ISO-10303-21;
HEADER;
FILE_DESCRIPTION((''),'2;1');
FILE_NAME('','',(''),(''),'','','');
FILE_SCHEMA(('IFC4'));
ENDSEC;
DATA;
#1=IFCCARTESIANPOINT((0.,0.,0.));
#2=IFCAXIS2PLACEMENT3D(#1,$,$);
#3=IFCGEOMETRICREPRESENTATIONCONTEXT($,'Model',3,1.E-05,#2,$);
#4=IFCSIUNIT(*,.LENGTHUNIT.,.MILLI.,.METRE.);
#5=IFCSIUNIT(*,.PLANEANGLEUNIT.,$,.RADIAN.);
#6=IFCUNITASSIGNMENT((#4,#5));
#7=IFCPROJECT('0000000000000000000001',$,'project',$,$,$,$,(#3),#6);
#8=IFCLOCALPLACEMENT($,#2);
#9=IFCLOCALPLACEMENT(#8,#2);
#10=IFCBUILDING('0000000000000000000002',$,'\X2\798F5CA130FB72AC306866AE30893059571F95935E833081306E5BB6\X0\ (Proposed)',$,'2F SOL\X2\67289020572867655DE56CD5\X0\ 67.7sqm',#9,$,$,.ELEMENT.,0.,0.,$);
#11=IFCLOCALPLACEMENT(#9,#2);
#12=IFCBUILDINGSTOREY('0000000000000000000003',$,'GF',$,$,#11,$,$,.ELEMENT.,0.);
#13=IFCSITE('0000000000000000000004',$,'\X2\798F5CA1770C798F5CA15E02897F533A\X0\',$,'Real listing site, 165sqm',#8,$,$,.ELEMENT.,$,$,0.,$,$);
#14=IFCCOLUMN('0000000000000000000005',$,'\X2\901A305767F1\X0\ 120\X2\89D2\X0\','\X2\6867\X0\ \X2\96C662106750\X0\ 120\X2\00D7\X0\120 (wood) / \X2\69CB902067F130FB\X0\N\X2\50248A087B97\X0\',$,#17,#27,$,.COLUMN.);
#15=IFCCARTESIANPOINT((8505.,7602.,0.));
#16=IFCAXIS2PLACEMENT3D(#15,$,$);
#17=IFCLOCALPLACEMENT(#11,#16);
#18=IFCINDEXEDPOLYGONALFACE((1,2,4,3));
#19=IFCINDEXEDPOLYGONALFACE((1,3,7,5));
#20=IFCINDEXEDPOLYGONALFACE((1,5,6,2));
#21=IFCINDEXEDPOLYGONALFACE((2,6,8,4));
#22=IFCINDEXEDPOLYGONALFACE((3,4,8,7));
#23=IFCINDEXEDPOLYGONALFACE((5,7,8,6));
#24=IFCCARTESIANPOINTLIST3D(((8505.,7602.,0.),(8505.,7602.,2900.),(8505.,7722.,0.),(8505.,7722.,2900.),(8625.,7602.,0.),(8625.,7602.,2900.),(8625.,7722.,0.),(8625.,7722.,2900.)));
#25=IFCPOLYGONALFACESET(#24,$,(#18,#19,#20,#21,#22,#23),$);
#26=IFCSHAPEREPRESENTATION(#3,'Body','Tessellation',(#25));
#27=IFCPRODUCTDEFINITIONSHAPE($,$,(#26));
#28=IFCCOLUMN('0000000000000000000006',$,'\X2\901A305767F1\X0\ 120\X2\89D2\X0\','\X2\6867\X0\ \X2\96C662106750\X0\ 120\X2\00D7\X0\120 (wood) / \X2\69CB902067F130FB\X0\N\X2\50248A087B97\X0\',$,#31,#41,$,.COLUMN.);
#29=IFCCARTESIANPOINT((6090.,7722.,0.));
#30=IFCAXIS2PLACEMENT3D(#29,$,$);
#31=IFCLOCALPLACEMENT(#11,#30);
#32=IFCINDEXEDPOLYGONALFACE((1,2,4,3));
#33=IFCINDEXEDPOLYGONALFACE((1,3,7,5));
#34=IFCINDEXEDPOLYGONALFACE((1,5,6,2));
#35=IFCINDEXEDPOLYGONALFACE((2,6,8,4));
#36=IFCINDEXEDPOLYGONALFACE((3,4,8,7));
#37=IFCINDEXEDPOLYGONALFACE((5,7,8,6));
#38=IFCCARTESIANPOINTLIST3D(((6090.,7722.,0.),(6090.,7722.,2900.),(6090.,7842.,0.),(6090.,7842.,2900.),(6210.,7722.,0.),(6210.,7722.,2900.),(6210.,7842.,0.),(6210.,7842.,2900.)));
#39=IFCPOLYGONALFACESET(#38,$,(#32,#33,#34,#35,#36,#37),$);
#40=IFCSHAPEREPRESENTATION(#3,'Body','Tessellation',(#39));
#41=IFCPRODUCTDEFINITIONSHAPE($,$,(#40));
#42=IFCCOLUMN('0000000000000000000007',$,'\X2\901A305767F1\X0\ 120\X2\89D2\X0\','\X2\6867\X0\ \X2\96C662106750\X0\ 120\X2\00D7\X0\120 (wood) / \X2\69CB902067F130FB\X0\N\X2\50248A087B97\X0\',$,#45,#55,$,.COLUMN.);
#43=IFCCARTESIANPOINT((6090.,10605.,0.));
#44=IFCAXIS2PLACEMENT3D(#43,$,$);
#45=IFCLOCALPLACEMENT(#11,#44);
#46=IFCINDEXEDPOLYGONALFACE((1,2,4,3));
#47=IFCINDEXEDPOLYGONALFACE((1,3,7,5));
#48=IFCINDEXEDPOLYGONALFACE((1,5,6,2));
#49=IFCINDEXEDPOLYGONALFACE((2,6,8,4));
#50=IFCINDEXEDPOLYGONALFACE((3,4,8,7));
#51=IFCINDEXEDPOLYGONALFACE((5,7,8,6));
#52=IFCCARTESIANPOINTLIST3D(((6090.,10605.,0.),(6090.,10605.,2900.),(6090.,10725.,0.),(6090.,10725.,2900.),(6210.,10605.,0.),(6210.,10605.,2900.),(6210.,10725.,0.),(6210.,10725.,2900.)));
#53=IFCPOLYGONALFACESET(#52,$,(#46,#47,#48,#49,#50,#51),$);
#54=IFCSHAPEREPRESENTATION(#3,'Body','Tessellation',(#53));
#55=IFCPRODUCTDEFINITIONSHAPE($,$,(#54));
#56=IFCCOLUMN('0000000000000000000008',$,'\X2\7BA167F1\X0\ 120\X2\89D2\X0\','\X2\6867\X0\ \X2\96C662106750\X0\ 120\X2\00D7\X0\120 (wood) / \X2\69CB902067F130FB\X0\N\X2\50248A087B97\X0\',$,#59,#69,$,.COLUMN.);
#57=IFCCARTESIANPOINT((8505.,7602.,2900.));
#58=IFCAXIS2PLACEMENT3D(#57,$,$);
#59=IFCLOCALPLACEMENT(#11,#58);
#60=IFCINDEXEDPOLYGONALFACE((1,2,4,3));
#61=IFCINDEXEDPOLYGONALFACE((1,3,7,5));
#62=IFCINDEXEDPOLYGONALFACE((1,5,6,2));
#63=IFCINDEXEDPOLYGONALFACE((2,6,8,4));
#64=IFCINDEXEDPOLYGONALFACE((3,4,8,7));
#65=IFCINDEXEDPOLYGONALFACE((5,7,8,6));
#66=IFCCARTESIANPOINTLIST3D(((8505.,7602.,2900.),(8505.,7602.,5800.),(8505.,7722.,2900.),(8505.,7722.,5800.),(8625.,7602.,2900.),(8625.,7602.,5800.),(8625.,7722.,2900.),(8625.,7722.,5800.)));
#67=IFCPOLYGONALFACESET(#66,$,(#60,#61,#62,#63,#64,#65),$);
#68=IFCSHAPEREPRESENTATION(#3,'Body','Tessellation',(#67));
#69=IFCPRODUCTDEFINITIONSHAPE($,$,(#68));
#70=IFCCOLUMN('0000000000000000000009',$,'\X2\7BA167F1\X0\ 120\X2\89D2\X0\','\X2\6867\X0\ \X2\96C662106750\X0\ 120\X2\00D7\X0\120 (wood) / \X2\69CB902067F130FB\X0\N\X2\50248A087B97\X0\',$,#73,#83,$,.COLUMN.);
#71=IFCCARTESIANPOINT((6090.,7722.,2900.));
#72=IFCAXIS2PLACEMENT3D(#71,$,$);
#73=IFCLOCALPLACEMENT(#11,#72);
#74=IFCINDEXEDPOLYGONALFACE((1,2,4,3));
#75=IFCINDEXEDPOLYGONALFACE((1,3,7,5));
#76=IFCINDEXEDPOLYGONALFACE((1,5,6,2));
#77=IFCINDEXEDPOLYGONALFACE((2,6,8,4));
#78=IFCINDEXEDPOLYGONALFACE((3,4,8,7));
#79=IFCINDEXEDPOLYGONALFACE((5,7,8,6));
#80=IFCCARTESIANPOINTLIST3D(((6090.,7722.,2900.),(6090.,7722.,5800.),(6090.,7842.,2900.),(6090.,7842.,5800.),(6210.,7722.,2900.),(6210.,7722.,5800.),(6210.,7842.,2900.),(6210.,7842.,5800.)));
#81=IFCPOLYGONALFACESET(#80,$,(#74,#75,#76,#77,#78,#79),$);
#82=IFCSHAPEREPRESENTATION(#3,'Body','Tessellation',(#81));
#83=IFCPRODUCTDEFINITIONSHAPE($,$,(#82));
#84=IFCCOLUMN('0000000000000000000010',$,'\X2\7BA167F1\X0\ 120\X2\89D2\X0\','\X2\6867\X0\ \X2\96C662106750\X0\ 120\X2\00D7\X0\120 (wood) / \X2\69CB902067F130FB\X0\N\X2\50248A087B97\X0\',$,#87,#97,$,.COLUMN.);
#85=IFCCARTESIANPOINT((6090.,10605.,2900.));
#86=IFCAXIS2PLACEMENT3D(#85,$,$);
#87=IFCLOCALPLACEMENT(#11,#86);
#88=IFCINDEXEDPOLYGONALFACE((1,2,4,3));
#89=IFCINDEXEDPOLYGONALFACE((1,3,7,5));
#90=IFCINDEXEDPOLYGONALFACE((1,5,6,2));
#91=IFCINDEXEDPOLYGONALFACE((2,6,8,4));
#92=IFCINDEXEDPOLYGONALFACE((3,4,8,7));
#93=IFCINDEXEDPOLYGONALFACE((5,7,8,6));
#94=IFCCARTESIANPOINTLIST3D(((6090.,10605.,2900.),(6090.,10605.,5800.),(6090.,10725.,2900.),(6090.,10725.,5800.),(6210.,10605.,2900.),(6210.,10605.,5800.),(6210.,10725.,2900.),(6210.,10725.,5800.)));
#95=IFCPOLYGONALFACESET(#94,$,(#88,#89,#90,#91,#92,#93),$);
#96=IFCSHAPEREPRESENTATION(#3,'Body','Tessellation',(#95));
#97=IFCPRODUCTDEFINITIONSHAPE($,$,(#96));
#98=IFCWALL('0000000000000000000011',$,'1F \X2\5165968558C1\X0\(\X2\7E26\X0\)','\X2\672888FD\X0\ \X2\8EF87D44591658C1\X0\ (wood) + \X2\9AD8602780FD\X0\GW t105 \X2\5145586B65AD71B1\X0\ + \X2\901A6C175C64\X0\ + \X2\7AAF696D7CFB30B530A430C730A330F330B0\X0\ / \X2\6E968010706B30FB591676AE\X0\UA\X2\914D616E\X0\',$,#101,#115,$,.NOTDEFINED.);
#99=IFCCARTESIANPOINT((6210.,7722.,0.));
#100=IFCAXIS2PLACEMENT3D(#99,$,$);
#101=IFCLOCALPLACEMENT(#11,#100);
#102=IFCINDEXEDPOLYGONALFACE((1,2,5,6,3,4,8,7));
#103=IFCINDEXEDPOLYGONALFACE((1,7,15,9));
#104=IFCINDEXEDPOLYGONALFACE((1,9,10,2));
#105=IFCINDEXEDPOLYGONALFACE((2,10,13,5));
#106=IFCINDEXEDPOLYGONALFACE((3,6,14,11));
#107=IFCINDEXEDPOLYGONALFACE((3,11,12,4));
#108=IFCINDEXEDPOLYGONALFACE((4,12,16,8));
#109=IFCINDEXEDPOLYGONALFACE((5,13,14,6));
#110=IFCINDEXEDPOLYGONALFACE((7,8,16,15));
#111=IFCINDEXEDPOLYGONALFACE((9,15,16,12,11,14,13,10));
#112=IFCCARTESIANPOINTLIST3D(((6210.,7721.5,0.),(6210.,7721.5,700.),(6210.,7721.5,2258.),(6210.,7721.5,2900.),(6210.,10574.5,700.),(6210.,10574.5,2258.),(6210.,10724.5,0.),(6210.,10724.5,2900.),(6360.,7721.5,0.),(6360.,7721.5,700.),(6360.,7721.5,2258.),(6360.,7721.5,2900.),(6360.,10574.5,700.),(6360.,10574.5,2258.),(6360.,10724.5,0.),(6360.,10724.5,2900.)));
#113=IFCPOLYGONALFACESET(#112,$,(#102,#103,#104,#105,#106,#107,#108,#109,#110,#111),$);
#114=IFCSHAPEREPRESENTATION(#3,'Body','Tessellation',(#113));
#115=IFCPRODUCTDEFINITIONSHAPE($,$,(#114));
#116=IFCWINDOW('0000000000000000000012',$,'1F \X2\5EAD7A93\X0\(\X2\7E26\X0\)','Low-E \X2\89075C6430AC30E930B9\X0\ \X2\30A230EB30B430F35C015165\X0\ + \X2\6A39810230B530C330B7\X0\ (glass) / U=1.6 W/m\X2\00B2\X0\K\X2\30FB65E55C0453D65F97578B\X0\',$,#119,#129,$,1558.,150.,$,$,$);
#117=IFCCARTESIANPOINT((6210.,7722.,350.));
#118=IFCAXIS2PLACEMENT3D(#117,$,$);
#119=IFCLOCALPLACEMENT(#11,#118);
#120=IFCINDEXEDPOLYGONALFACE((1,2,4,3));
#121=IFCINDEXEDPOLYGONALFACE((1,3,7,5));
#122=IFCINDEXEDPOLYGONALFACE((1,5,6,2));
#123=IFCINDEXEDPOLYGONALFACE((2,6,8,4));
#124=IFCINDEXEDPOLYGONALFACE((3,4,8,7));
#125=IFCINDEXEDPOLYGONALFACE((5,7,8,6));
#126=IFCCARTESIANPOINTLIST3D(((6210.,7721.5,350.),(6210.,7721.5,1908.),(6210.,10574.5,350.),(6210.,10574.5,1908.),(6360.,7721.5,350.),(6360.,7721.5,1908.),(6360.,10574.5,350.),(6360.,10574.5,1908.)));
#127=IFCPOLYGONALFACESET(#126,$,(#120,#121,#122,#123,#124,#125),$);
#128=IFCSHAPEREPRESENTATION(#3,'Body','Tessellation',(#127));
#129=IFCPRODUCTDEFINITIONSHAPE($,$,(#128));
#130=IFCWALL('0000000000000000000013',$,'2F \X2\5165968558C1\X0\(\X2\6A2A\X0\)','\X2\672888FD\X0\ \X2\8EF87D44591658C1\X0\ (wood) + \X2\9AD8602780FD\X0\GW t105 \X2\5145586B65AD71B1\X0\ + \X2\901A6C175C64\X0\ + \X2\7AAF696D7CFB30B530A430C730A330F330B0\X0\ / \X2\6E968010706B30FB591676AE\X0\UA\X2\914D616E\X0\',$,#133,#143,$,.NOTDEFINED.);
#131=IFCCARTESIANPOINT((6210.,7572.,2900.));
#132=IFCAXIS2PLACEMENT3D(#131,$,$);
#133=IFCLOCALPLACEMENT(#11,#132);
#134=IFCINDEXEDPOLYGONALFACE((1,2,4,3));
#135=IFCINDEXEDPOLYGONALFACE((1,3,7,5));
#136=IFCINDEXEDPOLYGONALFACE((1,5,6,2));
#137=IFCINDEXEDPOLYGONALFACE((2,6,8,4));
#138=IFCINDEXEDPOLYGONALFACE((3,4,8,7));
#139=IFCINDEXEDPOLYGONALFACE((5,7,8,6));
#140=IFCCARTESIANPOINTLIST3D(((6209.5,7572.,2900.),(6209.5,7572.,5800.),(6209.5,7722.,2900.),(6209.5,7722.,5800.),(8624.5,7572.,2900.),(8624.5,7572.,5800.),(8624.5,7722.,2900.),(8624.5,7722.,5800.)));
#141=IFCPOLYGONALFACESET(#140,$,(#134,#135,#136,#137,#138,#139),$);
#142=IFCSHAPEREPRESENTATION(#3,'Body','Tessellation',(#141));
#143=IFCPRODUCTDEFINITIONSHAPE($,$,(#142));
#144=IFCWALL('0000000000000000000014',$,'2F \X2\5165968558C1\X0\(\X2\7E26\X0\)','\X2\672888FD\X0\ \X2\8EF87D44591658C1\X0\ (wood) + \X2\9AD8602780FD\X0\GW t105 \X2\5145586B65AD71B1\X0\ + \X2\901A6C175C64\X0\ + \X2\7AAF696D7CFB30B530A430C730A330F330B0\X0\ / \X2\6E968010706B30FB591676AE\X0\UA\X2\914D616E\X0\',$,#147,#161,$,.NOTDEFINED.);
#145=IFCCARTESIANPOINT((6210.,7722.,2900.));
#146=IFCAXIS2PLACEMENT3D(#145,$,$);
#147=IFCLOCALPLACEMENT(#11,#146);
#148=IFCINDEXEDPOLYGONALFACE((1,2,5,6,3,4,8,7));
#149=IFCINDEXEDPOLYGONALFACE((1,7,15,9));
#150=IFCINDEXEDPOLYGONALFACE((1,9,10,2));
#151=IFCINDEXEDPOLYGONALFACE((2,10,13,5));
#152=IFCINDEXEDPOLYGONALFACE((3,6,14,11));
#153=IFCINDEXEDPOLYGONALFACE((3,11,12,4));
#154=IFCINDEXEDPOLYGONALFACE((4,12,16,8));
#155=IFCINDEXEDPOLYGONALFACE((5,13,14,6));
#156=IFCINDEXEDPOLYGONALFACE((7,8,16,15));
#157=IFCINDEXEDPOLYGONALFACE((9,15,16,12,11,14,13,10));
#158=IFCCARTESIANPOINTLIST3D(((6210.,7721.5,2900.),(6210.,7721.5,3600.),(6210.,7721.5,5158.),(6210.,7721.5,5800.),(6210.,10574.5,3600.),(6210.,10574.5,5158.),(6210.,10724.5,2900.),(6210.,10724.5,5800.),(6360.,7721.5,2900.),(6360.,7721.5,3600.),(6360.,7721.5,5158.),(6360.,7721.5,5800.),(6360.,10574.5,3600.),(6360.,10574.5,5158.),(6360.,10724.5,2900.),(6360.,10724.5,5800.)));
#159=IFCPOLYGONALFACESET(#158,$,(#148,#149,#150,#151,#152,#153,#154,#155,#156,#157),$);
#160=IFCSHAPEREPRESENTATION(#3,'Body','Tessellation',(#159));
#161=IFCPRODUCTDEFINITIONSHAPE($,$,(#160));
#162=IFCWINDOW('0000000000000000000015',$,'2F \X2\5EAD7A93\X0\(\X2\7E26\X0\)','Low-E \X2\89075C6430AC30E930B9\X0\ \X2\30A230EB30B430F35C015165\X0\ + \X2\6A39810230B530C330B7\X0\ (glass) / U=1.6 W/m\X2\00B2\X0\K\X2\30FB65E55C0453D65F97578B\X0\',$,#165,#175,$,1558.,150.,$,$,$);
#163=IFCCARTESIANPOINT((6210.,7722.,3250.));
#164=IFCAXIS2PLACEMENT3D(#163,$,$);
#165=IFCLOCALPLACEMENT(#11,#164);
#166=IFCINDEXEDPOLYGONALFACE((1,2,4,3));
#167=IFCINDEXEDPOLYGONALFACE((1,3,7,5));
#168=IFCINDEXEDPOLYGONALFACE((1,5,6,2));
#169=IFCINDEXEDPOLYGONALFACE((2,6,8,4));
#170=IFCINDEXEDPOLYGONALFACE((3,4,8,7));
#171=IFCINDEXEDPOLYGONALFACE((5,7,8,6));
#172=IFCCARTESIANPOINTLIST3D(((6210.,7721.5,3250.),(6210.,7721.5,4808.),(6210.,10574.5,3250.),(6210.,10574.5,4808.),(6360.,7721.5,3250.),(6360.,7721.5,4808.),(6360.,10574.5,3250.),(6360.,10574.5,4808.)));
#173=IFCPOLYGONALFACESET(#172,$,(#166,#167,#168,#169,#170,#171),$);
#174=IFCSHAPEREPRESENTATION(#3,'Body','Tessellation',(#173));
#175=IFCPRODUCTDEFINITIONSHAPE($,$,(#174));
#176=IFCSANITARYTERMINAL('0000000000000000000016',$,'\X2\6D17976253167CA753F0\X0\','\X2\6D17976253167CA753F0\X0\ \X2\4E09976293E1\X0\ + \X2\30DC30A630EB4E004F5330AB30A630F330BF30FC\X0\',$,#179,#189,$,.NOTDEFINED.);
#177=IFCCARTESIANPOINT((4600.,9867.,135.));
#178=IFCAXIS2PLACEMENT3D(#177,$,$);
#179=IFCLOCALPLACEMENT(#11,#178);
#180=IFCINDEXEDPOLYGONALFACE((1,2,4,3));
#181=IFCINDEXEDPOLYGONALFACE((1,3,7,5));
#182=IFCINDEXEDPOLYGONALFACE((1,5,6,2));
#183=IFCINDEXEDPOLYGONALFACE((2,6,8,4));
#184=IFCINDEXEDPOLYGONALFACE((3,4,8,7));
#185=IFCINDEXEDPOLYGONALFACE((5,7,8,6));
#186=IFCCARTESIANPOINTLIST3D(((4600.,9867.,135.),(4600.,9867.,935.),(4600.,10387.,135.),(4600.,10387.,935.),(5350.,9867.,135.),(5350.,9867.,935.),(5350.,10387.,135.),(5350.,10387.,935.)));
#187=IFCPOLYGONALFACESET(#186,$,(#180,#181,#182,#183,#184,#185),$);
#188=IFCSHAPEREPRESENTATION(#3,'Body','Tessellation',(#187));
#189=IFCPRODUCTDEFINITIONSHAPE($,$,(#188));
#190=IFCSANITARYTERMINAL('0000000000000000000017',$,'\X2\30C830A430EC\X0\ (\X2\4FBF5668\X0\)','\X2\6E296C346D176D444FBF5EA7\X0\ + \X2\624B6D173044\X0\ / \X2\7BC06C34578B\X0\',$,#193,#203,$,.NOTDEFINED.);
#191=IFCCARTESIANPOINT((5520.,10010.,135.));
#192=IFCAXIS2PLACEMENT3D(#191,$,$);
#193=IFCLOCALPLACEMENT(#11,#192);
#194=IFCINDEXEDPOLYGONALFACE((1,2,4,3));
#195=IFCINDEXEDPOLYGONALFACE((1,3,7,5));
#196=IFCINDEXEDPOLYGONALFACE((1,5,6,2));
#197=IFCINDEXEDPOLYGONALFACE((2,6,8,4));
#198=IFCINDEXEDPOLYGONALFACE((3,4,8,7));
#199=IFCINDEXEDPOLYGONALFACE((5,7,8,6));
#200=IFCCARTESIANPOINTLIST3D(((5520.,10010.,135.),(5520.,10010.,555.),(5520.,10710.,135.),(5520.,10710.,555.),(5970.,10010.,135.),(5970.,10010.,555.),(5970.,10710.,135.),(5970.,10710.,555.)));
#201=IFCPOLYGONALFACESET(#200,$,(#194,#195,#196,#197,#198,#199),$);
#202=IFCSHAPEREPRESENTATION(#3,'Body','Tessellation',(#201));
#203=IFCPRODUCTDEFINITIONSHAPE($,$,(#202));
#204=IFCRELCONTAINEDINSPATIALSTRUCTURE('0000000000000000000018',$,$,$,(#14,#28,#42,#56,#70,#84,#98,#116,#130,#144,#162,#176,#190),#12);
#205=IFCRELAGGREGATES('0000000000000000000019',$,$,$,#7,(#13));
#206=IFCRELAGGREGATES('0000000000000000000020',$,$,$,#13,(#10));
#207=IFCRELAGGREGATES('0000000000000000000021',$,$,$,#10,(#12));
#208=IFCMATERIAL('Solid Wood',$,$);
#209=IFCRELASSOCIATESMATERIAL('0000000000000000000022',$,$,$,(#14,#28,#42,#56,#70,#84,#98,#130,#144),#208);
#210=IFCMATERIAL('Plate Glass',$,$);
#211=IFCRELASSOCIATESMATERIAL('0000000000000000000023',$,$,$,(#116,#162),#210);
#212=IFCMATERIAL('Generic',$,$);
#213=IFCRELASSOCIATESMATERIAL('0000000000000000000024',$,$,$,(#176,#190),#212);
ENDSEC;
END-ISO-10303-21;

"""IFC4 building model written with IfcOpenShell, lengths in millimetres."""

from ifc_helpers import new_model, si_unit, frame, frame_2d, origin, place, context, project, spatial, rectangle, extrude, material, element, fill, save


model = new_model("IFC4")

# Units and contexts
model_context = context("Model", 3, precision=1e-05, world=origin())
ifc_project = project(units=[si_unit("LENGTHUNIT", "METRE", prefix="MILLI"), si_unit("PLANEANGLEUNIT", "RADIAN")], contexts=[model_context])

# Site, building, storey
site_placement = place(None, origin())
site = spatial("IfcSite", under=ifc_project, at=site_placement, Name="福岡県福岡市西区", ObjectType="Real listing site, 165sqm", CompositionType="ELEMENT", RefElevation=0.0)
building_placement = place(site_placement, origin())
building = spatial("IfcBuilding", under=site, at=building_placement, Name="福岡・犬と暮らす土間広めの家 (Proposed)", ObjectType="2F SOL木造在来工法 67.7sqm", CompositionType="ELEMENT", ElevationOfRefHeight=0.0, ElevationOfTerrain=0.0)
storey_placement = place(building_placement, origin())
storey = spatial("IfcBuildingStorey", under=building, at=storey_placement, Name="GF", CompositionType="ELEMENT", Elevation=0.0)

# Columns
ifc_material_1 = material(Name="Solid Wood")
column_1_placement = place(storey_placement, frame((8505.0, 7602.0, 0.0)))
element("IfcColumn", 1, at=column_1_placement, inside=storey, material=ifc_material_1, Name="通し柱 120角", Description="桧 集成材 120×120 (wood) / 構造柱・N値計算", PredefinedType="COLUMN", context=model_context, shape_type="SweptSolid", body=[
    extrude(rectangle(XDim=120.0, YDim=120.0, at=frame_2d((60.0, 60.0))), frame((8505.0, 7602.0, 0.0)), (0.0, 0.0, 1.0), 2900.0),
])
column_2_placement = place(storey_placement, frame((6090.0, 7722.0, 0.0)))
element("IfcColumn", 2, at=column_2_placement, inside=storey, material=ifc_material_1, Name="通し柱 120角", Description="桧 集成材 120×120 (wood) / 構造柱・N値計算", PredefinedType="COLUMN", context=model_context, shape_type="SweptSolid", body=[
    extrude(rectangle(XDim=120.0, YDim=120.0, at=frame_2d((60.0, 60.0))), frame((6090.0, 7722.0, 0.0)), (0.0, 0.0, 1.0), 2900.0),
])
column_3_placement = place(storey_placement, frame((6090.0, 10605.0, 0.0)))
element("IfcColumn", 3, at=column_3_placement, inside=storey, material=ifc_material_1, Name="通し柱 120角", Description="桧 集成材 120×120 (wood) / 構造柱・N値計算", PredefinedType="COLUMN", context=model_context, shape_type="SweptSolid", body=[
    extrude(rectangle(XDim=120.0, YDim=120.0, at=frame_2d((60.0, 60.0))), frame((6090.0, 10605.0, 0.0)), (0.0, 0.0, 1.0), 2900.0),
])
column_4_placement = place(storey_placement, frame((8505.0, 7602.0, 2900.0)))
element("IfcColumn", 4, at=column_4_placement, inside=storey, material=ifc_material_1, Name="管柱 120角", Description="桧 集成材 120×120 (wood) / 構造柱・N値計算", PredefinedType="COLUMN", context=model_context, shape_type="SweptSolid", body=[
    extrude(rectangle(XDim=120.0, YDim=120.0, at=frame_2d((60.0, 60.0))), frame((8505.0, 7602.0, 2900.0)), (0.0, 0.0, 1.0), 2900.0),
])
column_5_placement = place(storey_placement, frame((6090.0, 7722.0, 2900.0)))
element("IfcColumn", 5, at=column_5_placement, inside=storey, material=ifc_material_1, Name="管柱 120角", Description="桧 集成材 120×120 (wood) / 構造柱・N値計算", PredefinedType="COLUMN", context=model_context, shape_type="SweptSolid", body=[
    extrude(rectangle(XDim=120.0, YDim=120.0, at=frame_2d((60.0, 60.0))), frame((6090.0, 7722.0, 2900.0)), (0.0, 0.0, 1.0), 2900.0),
])
column_6_placement = place(storey_placement, frame((6090.0, 10605.0, 2900.0)))
element("IfcColumn", 6, at=column_6_placement, inside=storey, material=ifc_material_1, Name="管柱 120角", Description="桧 集成材 120×120 (wood) / 構造柱・N値計算", PredefinedType="COLUMN", context=model_context, shape_type="SweptSolid", body=[
    extrude(rectangle(XDim=120.0, YDim=120.0, at=frame_2d((60.0, 60.0))), frame((6090.0, 10605.0, 2900.0)), (0.0, 0.0, 1.0), 2900.0),
])

# Wall, opening, window
wall_1_placement = place(storey_placement, frame((6210.0, 7722.0, 0.0)))
wall_1 = element("IfcWall", 7, at=wall_1_placement, inside=storey, material=ifc_material_1, Name="1F 入隅壁(縦)", Description="木製 軸組外壁 (wood) + 高性能GW t105 充填断熱 + 通気層 + 窯業系サイディング / 準耐火・外皮UA配慮", PredefinedType="NOTDEFINED", context=model_context, shape_type="SweptSolid", body=[
    extrude(rectangle(XDim=150.0, YDim=3003.0, at=frame_2d((75.0, 1501.0))), frame((6210.0, 7722.0, 0.0)), (0.0, 0.0, 1.0), 2900.0),
])
opening_1_placement = place(storey_placement, frame((6210.0, 7722.0, 350.0)))
opening_1 = element("IfcOpeningElement", 8, at=opening_1_placement, cuts=wall_1, PredefinedType="NOTDEFINED", context=model_context, shape_type="SweptSolid", body=[
    extrude(rectangle(XDim=150.0, YDim=2853.0, at=frame_2d((75.0, 1426.0))), frame((6210.0, 7722.0, 350.0)), (0.0, 0.0, 1.0), 1558.0),
])
ifc_material_2 = material(Name="Plate Glass")
window_1_placement = place(storey_placement, frame((6210.0, 7722.0, 350.0)))
window_1 = element("IfcWindow", 9, at=window_1_placement, inside=storey, material=ifc_material_2, Name="1F 庭窓(縦)", Description="Low-E 複層ガラス アルゴン封入 + 樹脂サッシ (glass) / U=1.6 W/m²K・日射取得型", OverallHeight=1558.0, OverallWidth=150.0, context=model_context, shape_type="SweptSolid", body=[
    extrude(rectangle(XDim=150.0, YDim=2853.0, at=frame_2d((75.0, 1426.0))), frame((6210.0, 7722.0, 350.0)), (0.0, 0.0, 1.0), 1558.0),
])
fill(opening_1, window_1)

# Wall
wall_2_placement = place(storey_placement, frame((6210.0, 7572.0, 2900.0)))
element("IfcWall", 10, at=wall_2_placement, inside=storey, material=ifc_material_1, Name="2F 入隅壁(横)", Description="木製 軸組外壁 (wood) + 高性能GW t105 充填断熱 + 通気層 + 窯業系サイディング / 準耐火・外皮UA配慮", PredefinedType="NOTDEFINED", context=model_context, shape_type="SweptSolid", body=[
    extrude(rectangle(XDim=2415.0, YDim=150.0, at=frame_2d((1207.0, 75.0))), frame((6210.0, 7572.0, 2900.0)), (0.0, 0.0, 1.0), 2900.0),
])

# Wall, opening, window
wall_3_placement = place(storey_placement, frame((6210.0, 7722.0, 2900.0)))
wall_3 = element("IfcWall", 11, at=wall_3_placement, inside=storey, material=ifc_material_1, Name="2F 入隅壁(縦)", Description="木製 軸組外壁 (wood) + 高性能GW t105 充填断熱 + 通気層 + 窯業系サイディング / 準耐火・外皮UA配慮", PredefinedType="NOTDEFINED", context=model_context, shape_type="SweptSolid", body=[
    extrude(rectangle(XDim=150.0, YDim=3003.0, at=frame_2d((75.0, 1501.0))), frame((6210.0, 7722.0, 2900.0)), (0.0, 0.0, 1.0), 2900.0),
])
opening_2_placement = place(storey_placement, frame((6210.0, 7722.0, 3250.0)))
opening_2 = element("IfcOpeningElement", 12, at=opening_2_placement, cuts=wall_3, PredefinedType="NOTDEFINED", context=model_context, shape_type="SweptSolid", body=[
    extrude(rectangle(XDim=150.0, YDim=2853.0, at=frame_2d((75.0, 1426.0))), frame((6210.0, 7722.0, 3250.0)), (0.0, 0.0, 1.0), 1558.0),
])
window_2_placement = place(storey_placement, frame((6210.0, 7722.0, 3250.0)))
window_2 = element("IfcWindow", 13, at=window_2_placement, inside=storey, material=ifc_material_2, Name="2F 庭窓(縦)", Description="Low-E 複層ガラス アルゴン封入 + 樹脂サッシ (glass) / U=1.6 W/m²K・日射取得型", OverallHeight=1558.0, OverallWidth=150.0, context=model_context, shape_type="SweptSolid", body=[
    extrude(rectangle(XDim=150.0, YDim=2853.0, at=frame_2d((75.0, 1426.0))), frame((6210.0, 7722.0, 3250.0)), (0.0, 0.0, 1.0), 1558.0),
])
fill(opening_2, window_2)

# Sanitary terminals
ifc_material_3 = material(Name="Generic")
sanitary_terminal_1_placement = place(storey_placement, frame((4600.0, 9867.0, 135.0)))
element("IfcSanitaryTerminal", 14, at=sanitary_terminal_1_placement, inside=storey, material=ifc_material_3, Name="洗面化粧台", Description="洗面化粧台 三面鏡 + ボウル一体カウンター", PredefinedType="NOTDEFINED", context=model_context, shape_type="SweptSolid", body=[
    extrude(rectangle(XDim=750.0, YDim=520.0, at=frame_2d((375.0, 260.0))), frame((4600.0, 9867.0, 135.0)), (0.0, 0.0, 1.0), 800.0),
])
sanitary_terminal_2_placement = place(storey_placement, frame((5520.0, 10010.0, 135.0)))
element("IfcSanitaryTerminal", 15, at=sanitary_terminal_2_placement, inside=storey, material=ifc_material_3, Name="トイレ (便器)", Description="温水洗浄便座 + 手洗い / 節水型", PredefinedType="NOTDEFINED", context=model_context, shape_type="SweptSolid", body=[
    extrude(rectangle(XDim=450.0, YDim=700.0, at=frame_2d((225.0, 350.0))), frame((5520.0, 10010.0, 135.0)), (0.0, 0.0, 1.0), 420.0),
])

save(model, "model.ifc")
